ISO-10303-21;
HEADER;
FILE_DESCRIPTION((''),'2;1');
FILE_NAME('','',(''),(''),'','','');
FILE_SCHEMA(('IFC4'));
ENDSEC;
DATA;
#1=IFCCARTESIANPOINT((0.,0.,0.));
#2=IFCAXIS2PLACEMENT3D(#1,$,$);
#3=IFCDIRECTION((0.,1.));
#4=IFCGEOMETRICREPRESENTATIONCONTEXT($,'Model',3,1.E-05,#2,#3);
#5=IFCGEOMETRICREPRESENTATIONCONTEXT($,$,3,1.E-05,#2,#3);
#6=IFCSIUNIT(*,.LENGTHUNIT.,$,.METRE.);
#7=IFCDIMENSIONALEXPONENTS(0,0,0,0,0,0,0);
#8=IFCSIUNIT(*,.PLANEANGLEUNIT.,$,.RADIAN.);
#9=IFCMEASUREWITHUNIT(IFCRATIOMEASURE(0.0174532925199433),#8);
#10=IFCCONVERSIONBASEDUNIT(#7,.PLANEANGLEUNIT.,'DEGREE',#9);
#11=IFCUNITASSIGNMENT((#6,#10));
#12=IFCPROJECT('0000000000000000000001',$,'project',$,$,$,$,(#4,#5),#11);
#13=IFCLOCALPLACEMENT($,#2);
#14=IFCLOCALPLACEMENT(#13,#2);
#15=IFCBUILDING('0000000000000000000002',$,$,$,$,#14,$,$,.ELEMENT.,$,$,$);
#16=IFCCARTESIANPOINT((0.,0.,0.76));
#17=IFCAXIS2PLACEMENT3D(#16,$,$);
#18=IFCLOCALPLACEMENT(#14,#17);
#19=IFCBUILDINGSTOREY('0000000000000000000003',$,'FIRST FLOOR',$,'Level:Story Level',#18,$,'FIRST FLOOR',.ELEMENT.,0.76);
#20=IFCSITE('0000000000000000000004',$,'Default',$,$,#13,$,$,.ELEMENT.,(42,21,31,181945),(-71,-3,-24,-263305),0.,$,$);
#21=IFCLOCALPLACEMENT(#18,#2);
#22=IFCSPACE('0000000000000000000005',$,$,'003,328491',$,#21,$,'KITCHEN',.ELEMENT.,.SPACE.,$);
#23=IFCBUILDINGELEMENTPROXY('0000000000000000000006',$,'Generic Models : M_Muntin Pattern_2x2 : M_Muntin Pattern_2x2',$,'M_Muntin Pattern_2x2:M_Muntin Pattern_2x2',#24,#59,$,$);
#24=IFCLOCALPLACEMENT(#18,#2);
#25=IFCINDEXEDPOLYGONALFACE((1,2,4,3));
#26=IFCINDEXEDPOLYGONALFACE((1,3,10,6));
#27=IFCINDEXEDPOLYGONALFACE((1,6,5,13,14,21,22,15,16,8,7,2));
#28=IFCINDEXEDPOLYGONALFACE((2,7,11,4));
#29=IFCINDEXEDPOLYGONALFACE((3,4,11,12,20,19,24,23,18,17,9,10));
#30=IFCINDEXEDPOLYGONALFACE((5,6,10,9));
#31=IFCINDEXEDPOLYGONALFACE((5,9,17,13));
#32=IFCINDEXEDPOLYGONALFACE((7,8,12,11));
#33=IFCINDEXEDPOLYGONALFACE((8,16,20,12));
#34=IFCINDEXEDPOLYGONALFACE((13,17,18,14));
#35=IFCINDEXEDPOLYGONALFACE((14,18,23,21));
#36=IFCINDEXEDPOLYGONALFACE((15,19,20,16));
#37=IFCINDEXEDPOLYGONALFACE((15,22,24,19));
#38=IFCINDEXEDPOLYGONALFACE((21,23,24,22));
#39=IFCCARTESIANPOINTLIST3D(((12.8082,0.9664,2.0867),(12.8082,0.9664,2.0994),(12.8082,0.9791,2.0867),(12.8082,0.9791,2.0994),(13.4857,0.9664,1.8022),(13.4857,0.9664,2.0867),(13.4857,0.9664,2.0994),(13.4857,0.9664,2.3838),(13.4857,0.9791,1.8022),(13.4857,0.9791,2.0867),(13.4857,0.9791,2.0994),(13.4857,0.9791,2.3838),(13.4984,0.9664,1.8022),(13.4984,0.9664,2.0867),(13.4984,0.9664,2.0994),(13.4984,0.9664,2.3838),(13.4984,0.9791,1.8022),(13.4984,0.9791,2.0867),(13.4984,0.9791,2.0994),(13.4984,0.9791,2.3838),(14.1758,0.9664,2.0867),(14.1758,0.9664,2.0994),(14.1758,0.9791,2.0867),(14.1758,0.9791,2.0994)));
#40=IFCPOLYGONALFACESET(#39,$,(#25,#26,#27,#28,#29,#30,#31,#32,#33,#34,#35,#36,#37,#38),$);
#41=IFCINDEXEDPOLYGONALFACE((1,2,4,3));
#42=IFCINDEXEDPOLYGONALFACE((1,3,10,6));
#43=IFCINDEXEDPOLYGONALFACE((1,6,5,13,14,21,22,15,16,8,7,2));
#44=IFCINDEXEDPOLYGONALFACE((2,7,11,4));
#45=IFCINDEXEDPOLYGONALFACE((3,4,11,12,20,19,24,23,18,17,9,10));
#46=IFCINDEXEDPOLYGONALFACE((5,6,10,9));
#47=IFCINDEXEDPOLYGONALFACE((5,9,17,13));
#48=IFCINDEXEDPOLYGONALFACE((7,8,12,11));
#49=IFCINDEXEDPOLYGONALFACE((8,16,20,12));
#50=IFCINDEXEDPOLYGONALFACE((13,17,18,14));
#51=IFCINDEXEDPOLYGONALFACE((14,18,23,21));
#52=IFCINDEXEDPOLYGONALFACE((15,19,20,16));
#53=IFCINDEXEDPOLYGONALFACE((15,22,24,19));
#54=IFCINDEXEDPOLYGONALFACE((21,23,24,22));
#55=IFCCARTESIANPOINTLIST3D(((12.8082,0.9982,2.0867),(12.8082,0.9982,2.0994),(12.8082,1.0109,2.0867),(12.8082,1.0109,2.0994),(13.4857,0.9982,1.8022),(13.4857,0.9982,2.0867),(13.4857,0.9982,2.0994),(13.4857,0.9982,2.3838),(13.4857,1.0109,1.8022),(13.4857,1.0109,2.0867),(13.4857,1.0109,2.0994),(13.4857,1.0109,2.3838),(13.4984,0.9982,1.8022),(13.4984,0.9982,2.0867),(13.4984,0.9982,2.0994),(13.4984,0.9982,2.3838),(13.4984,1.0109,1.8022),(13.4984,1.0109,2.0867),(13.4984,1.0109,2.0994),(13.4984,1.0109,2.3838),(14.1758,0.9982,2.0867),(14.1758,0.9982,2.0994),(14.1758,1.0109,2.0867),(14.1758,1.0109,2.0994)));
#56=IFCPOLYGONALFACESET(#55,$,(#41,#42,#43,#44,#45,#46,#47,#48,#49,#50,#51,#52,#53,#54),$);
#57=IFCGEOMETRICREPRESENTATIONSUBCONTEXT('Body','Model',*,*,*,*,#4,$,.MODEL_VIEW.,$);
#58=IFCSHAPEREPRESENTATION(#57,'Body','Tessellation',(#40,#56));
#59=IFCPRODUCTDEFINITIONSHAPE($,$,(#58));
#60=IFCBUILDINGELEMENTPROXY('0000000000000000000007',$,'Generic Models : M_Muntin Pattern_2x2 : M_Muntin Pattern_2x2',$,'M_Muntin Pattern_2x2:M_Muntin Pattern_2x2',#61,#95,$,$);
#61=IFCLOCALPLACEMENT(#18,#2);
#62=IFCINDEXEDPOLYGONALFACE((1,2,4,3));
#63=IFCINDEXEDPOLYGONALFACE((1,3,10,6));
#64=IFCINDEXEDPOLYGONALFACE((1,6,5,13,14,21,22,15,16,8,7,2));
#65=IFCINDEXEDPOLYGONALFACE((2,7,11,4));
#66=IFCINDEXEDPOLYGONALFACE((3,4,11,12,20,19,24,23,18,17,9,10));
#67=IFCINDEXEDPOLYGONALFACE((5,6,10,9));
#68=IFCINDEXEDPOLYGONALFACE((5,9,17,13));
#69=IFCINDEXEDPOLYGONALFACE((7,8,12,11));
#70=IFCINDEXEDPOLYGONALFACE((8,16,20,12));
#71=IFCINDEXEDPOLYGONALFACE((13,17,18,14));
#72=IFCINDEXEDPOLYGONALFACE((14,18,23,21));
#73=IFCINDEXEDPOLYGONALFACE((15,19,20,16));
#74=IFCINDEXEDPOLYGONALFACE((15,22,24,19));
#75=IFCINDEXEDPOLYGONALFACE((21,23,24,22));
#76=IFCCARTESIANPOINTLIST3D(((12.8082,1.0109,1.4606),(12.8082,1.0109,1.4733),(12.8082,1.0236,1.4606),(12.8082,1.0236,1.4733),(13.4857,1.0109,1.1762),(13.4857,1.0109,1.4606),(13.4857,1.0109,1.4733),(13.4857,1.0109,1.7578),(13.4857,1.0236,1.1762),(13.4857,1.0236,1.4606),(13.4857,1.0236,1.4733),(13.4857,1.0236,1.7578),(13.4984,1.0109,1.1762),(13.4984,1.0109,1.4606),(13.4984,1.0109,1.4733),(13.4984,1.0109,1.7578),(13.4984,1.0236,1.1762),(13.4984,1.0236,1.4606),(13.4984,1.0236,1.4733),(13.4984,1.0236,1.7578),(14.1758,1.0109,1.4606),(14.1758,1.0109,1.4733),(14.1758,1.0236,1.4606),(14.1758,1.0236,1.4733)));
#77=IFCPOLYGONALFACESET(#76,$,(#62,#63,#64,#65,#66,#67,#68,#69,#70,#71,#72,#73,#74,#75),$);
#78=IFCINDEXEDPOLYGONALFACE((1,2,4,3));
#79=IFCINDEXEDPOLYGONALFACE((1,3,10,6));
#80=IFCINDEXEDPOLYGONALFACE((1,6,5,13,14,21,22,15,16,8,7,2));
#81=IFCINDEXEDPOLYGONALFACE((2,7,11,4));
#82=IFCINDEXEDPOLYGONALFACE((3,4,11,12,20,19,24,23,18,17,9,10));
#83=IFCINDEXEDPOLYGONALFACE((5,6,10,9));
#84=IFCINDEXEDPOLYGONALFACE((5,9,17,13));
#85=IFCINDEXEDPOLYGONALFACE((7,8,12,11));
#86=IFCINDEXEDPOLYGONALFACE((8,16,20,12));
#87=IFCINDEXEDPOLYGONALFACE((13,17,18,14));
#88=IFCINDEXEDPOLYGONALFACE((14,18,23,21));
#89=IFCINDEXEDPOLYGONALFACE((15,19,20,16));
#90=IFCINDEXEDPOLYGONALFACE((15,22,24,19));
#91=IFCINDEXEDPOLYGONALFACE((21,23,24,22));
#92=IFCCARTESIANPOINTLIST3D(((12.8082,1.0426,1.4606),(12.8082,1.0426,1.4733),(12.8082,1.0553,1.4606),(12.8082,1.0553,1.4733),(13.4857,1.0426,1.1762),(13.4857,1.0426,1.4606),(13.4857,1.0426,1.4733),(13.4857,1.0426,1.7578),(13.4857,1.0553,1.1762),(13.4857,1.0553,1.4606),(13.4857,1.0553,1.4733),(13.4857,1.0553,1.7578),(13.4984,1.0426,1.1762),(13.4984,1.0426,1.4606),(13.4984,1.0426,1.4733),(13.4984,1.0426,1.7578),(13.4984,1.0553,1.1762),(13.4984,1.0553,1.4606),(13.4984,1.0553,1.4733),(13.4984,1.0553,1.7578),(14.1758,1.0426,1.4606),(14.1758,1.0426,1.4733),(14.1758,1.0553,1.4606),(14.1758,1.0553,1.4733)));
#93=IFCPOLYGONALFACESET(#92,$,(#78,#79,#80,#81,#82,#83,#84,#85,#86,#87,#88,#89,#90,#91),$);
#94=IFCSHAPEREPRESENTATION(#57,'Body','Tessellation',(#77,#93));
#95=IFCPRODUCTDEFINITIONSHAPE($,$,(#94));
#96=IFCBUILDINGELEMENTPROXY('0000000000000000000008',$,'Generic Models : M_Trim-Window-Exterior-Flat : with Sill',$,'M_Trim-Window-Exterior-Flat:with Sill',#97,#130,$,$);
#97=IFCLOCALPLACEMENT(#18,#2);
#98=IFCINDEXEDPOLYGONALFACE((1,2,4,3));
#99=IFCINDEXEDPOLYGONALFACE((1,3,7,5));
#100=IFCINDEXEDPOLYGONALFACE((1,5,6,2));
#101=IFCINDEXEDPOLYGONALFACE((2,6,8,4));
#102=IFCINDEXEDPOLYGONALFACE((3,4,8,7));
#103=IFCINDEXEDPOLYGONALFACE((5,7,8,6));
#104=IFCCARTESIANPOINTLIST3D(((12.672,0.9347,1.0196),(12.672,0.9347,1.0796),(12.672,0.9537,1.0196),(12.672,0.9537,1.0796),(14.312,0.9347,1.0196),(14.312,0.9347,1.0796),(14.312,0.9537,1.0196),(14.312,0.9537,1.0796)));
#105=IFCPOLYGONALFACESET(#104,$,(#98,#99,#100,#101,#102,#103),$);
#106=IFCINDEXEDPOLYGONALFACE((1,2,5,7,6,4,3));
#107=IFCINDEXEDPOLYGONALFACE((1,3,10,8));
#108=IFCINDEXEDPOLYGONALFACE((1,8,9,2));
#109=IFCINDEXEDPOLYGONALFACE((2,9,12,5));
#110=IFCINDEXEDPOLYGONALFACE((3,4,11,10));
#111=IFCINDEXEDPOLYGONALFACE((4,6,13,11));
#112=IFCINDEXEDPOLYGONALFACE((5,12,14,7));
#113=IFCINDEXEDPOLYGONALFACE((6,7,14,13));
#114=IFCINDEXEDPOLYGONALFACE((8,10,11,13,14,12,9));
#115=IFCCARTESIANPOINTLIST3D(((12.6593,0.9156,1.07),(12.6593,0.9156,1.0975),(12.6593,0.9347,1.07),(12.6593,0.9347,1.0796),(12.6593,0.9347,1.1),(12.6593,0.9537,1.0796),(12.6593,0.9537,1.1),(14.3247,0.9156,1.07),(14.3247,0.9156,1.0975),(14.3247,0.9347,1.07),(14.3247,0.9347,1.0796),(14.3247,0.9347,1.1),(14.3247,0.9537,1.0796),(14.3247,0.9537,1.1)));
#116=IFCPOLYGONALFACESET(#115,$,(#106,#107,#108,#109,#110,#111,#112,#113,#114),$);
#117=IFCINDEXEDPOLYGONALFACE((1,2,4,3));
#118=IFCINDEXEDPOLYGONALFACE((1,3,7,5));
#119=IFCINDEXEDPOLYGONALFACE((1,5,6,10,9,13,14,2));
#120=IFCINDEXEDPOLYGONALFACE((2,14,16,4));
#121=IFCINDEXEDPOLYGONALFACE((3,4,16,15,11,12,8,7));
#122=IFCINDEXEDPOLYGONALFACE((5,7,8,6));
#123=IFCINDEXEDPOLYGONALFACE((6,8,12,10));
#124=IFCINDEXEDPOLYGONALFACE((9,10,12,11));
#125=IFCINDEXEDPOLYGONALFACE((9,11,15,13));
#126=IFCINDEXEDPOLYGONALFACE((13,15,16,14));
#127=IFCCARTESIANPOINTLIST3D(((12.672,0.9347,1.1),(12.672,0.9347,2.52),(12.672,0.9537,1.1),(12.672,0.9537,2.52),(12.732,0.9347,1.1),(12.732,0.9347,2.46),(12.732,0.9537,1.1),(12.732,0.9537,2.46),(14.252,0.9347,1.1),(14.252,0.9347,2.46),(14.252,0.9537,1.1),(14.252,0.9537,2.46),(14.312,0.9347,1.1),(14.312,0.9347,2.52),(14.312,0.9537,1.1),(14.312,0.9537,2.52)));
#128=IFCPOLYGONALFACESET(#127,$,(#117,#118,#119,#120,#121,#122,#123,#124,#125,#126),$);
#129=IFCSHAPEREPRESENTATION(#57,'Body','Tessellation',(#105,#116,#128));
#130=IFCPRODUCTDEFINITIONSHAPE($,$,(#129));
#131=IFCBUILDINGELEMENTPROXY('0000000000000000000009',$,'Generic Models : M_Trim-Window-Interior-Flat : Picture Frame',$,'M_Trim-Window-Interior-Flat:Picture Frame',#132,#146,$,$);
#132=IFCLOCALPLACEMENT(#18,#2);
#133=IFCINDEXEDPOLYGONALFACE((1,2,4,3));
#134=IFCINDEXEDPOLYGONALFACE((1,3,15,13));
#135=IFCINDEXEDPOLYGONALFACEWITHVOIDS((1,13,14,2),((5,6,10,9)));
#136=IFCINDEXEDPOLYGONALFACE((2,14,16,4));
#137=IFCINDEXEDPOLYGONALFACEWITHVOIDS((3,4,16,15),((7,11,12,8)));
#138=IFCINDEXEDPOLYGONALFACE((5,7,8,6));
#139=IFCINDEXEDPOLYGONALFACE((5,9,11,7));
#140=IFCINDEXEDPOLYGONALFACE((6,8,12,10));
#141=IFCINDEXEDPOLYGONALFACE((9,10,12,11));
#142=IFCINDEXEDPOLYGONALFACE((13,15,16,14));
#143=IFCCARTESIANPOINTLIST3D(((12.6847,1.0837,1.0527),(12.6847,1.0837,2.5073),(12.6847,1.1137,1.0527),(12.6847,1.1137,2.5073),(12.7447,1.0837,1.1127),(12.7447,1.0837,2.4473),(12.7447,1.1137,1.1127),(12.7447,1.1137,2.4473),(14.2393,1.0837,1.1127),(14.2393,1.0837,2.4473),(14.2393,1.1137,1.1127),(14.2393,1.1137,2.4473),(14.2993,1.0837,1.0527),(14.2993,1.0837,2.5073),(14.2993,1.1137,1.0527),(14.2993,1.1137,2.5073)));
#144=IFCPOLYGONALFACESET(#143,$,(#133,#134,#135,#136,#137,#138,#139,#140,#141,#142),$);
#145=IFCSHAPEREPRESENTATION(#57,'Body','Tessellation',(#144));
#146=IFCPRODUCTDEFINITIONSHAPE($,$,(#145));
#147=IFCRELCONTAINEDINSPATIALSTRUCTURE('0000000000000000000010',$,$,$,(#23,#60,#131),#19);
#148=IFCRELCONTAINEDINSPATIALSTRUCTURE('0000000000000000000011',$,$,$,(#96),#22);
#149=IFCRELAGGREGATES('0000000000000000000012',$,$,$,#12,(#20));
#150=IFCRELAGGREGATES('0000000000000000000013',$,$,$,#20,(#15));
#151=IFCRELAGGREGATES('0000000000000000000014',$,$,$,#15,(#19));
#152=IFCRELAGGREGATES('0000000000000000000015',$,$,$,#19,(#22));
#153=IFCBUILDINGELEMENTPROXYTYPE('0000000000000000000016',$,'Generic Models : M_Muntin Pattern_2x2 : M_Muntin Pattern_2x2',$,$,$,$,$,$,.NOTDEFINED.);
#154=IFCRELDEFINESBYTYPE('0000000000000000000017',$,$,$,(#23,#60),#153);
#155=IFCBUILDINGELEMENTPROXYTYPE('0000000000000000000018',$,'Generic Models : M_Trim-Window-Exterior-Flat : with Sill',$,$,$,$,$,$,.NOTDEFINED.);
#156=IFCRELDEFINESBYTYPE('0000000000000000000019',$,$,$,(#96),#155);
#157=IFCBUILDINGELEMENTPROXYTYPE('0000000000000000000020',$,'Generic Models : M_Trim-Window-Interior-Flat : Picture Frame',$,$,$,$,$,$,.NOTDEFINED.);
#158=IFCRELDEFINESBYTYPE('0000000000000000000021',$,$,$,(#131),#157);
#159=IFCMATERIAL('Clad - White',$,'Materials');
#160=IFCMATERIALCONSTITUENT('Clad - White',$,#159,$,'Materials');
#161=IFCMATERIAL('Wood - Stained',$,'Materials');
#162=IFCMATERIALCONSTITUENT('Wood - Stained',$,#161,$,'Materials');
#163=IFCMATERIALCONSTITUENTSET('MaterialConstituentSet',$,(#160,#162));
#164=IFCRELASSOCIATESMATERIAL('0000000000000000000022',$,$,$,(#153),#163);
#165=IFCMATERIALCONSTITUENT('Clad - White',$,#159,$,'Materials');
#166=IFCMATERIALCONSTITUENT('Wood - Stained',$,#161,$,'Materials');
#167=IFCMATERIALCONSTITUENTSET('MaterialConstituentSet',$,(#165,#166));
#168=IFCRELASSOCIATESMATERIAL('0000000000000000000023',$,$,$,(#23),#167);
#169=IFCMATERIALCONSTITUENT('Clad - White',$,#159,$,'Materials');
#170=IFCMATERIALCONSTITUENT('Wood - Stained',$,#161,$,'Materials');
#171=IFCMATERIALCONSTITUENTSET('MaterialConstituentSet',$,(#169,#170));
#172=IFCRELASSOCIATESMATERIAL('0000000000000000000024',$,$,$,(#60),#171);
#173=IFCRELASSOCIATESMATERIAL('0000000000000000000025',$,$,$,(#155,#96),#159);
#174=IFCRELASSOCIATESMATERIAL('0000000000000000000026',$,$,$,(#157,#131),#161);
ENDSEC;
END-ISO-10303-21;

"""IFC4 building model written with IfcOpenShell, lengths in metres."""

from ifc_helpers import new_model, entity, si_unit, converted_unit, direction, frame, frame_2d, origin, place, context, subcontext, project, spatial, polyline, rectangle, outline, extrude, source, transform, mapped, material, constituent, constituent_set, type_object, type_shapes, element, save


model = new_model("IFC4")

# Units and contexts
model_context = context("Model", 3, precision=1e-05, world=origin(), true_north=direction((0.0, 1.0)))
context_of_model = context(None, 3, precision=1e-05, world=origin(), true_north=direction((0.0, 1.0)))
body_context = subcontext(model_context, "Body", "Model", "MODEL_VIEW")
ifc_project = project(units=[si_unit("LENGTHUNIT", "METRE"), converted_unit("PLANEANGLEUNIT", "DEGREE", entity("IfcRatioMeasure", 0.0174532925199433), si_unit("PLANEANGLEUNIT", "RADIAN"), dimensions=[0, 0, 0, 0, 0, 0, 0])], contexts=[model_context, context_of_model])

# Site, building, storey
site_placement = place(None, origin())
site = spatial("IfcSite", under=ifc_project, at=site_placement, Name="Default", CompositionType="ELEMENT", RefLatitude=(42, 21, 31, 181945), RefLongitude=(-71, -3, -24, -263305), RefElevation=0.0)
building_placement = place(site_placement, origin())
building = spatial("IfcBuilding", under=site, at=building_placement, CompositionType="ELEMENT")
storey_placement = place(building_placement, frame((0.0, 0.0, 0.76)))
storey = spatial("IfcBuildingStorey", under=building, at=storey_placement, Name="FIRST FLOOR", ObjectType="Level:Story Level", LongName="FIRST FLOOR", CompositionType="ELEMENT", Elevation=0.76)

# Shared definitions
ifc_material_1 = material(Name="Wood - Stained", Category="Materials")

# Shared definitions
ifc_material_2 = material(Name="Clad - White", Category="Materials")

# Shared definitions
space_1_placement = place(storey_placement, origin())
space_1 = spatial("IfcSpace", under=storey, at=space_1_placement, Description="003,328491", LongName="KITCHEN", CompositionType="ELEMENT", PredefinedType="SPACE")

# Building element proxies
ifc_constituent_1 = constituent(ifc_material_2, Name="Clad - White", Category="Materials")
ifc_constituent_2 = constituent(ifc_material_1, Name="Wood - Stained", Category="Materials")
ifc_constituent_set_1 = constituent_set(constituents=[ifc_constituent_1, ifc_constituent_2], Name="MaterialConstituentSet")
ifc_constituent_3 = constituent(ifc_material_2, Name="Clad - White", Category="Materials")
ifc_constituent_4 = constituent(ifc_material_1, Name="Wood - Stained", Category="Materials")
ifc_constituent_set_2 = constituent_set(constituents=[ifc_constituent_3, ifc_constituent_4], Name="MaterialConstituentSet")
building_element_proxy_type_1 = type_object("IfcBuildingElementProxyType", Name="Generic Models : M_Muntin Pattern_2x2 : M_Muntin Pattern_2x2", PredefinedType="NOTDEFINED", material=ifc_constituent_set_2)
shared_shape_1 = source(origin(), body_context, "Body", "SweptSolid", [
    extrude(outline(polyline([(0.0064, -0.0064), (0.2908, -0.0064), (0.2908, 0.0063), (0.0064, 0.0063), (0.0064, 0.6838), (-0.0063, 0.6838), (-0.0063, 0.0063), (-0.2908, 0.0063), (-0.2908, -0.0064), (-0.0063, -0.0064), (-0.0063, -0.6838), (0.0064, -0.6838), (0.0064, -0.0064)])), frame((0.0, 0.0095, 0.2908), z_axis=(0.0, 1.0, 0.0), x_axis=(0.0, 0.0, 1.0)), (0.0, 0.0, 1.0), 0.0127),
    extrude(outline(polyline([(0.0064, -0.0064), (0.2908, -0.0064), (0.2908, 0.0063), (0.0064, 0.0063), (0.0064, 0.6838), (-0.0063, 0.6838), (-0.0063, 0.0063), (-0.2908, 0.0063), (-0.2908, -0.0064), (-0.0063, -0.0064), (-0.0063, -0.6838), (0.0064, -0.6838), (0.0064, -0.0064)])), frame((0.0, -0.0222, 0.2908), z_axis=(0.0, 1.0, 0.0), x_axis=(0.0, 0.0, 1.0)), (0.0, 0.0, 1.0), 0.0127),
])
type_shapes(building_element_proxy_type_1, [shared_shape_1])
proxy_1_placement = place(storey_placement, frame((13.492, 0.9887, 1.8022), z_axis=(0.0, 0.0, 1.0), x_axis=(-1.0, 0.0, 0.0)))
element("IfcBuildingElementProxy", 1, at=proxy_1_placement, inside=storey, type_object=building_element_proxy_type_1, material=ifc_constituent_set_1, Name="Generic Models : M_Muntin Pattern_2x2 : M_Muntin Pattern_2x2", ObjectType="M_Muntin Pattern_2x2:M_Muntin Pattern_2x2", context=body_context, shape_type="MappedRepresentation", body=[
    mapped(shared_shape_1, transform((0.0, 0.0, 0.0), scale=1.0)),
])
ifc_constituent_5 = constituent(ifc_material_2, Name="Clad - White", Category="Materials")
ifc_constituent_6 = constituent(ifc_material_1, Name="Wood - Stained", Category="Materials")
ifc_constituent_set_3 = constituent_set(constituents=[ifc_constituent_5, ifc_constituent_6], Name="MaterialConstituentSet")
proxy_2_placement = place(storey_placement, frame((13.492, 1.0331, 1.1762), z_axis=(0.0, 0.0, 1.0), x_axis=(-1.0, 0.0, 0.0)))
element("IfcBuildingElementProxy", 2, at=proxy_2_placement, inside=storey, type_object=building_element_proxy_type_1, material=ifc_constituent_set_3, Name="Generic Models : M_Muntin Pattern_2x2 : M_Muntin Pattern_2x2", ObjectType="M_Muntin Pattern_2x2:M_Muntin Pattern_2x2", context=body_context, shape_type="MappedRepresentation", body=[
    mapped(shared_shape_1, transform((0.0, 0.0, 0.0), scale=1.0)),
])
building_element_proxy_type_2 = type_object("IfcBuildingElementProxyType", Name="Generic Models : M_Trim-Window-Exterior-Flat : with Sill", PredefinedType="NOTDEFINED", material=ifc_material_2)
shared_shape_2 = source(origin(), body_context, "Body", "SweptSolid", [
    extrude(rectangle(XDim=1.64, YDim=0.06, at=frame_2d((0.0, 0.0), x_axis=(1.0, 0.0))), frame((0.0, -1.4104, 0.0), z_axis=(0.0, 0.0, 1.0), x_axis=(-1.0, 0.0, 0.0)), (0.0, 0.0, 1.0), 0.0191),
    extrude(outline(polyline([(-0.019, -0.0152), (0.0, -0.0152), (0.0, -0.0057), (0.019, -0.0057), (0.019, 0.0148), (0.0, 0.0148), (-0.019, 0.0123), (-0.019, -0.0152)])), frame((-0.8327, -1.3748, 0.019), z_axis=(1.0, 0.0, 0.0), x_axis=(0.0, 0.0, -1.0)), (0.0, 0.0, 1.0), 1.6654),
    extrude(outline(polyline([(-0.725, -0.82), (0.695, -0.82), (0.695, -0.76), (-0.665, -0.76), (-0.665, 0.76), (0.695, 0.76), (0.695, 0.82), (-0.725, 0.82), (-0.725, -0.82)])), frame((0.0, -0.665, 0.0), z_axis=(0.0, 0.0, 1.0), x_axis=(0.0, -1.0, 0.0)), (0.0, 0.0, 1.0), 0.0191),
])
type_shapes(building_element_proxy_type_2, [shared_shape_2])
proxy_3_placement = place(space_1_placement, frame((13.492, 0.9537, 2.46), z_axis=(0.0, -1.0, 0.0), x_axis=(1.0, 0.0, 0.0)))
element("IfcBuildingElementProxy", 3, at=proxy_3_placement, inside=space_1, type_object=building_element_proxy_type_2, material=ifc_material_2, Name="Generic Models : M_Trim-Window-Exterior-Flat : with Sill", ObjectType="M_Trim-Window-Exterior-Flat:with Sill", context=body_context, shape_type="MappedRepresentation", body=[
    mapped(shared_shape_2, transform((0.0, 0.0, 0.0), scale=1.0)),
])
building_element_proxy_type_3 = type_object("IfcBuildingElementProxyType", Name="Generic Models : M_Trim-Window-Interior-Flat : Picture Frame", PredefinedType="NOTDEFINED", material=ifc_material_1)
shared_shape_3 = source(origin(), body_context, "Body", "SweptSolid", [
    extrude(outline(polyline([(-0.8073, -0.7273), (0.8073, -0.7273), (0.8073, 0.7273), (-0.8073, 0.7273), (-0.8073, -0.7273)]), holes=[polyline([(-0.7473, -0.6673), (-0.7473, 0.6673), (0.7473, 0.6673), (0.7473, -0.6673), (-0.7473, -0.6673)])]), frame((0.0, -0.68, 0.0), z_axis=(0.0, 0.0, 1.0), x_axis=(-1.0, 0.0, 0.0)), (0.0, 0.0, 1.0), 0.03),
])
type_shapes(building_element_proxy_type_3, [shared_shape_3])
proxy_4_placement = place(storey_placement, frame((13.492, 1.0837, 2.46), z_axis=(0.0, 1.0, 0.0), x_axis=(-1.0, 0.0, 0.0)))
element("IfcBuildingElementProxy", 4, at=proxy_4_placement, inside=storey, type_object=building_element_proxy_type_3, material=ifc_material_1, Name="Generic Models : M_Trim-Window-Interior-Flat : Picture Frame", ObjectType="M_Trim-Window-Interior-Flat:Picture Frame", context=body_context, shape_type="MappedRepresentation", body=[
    mapped(shared_shape_3, transform((0.0, 0.0, 0.0), scale=1.0)),
])

save(model, "model.ifc")
